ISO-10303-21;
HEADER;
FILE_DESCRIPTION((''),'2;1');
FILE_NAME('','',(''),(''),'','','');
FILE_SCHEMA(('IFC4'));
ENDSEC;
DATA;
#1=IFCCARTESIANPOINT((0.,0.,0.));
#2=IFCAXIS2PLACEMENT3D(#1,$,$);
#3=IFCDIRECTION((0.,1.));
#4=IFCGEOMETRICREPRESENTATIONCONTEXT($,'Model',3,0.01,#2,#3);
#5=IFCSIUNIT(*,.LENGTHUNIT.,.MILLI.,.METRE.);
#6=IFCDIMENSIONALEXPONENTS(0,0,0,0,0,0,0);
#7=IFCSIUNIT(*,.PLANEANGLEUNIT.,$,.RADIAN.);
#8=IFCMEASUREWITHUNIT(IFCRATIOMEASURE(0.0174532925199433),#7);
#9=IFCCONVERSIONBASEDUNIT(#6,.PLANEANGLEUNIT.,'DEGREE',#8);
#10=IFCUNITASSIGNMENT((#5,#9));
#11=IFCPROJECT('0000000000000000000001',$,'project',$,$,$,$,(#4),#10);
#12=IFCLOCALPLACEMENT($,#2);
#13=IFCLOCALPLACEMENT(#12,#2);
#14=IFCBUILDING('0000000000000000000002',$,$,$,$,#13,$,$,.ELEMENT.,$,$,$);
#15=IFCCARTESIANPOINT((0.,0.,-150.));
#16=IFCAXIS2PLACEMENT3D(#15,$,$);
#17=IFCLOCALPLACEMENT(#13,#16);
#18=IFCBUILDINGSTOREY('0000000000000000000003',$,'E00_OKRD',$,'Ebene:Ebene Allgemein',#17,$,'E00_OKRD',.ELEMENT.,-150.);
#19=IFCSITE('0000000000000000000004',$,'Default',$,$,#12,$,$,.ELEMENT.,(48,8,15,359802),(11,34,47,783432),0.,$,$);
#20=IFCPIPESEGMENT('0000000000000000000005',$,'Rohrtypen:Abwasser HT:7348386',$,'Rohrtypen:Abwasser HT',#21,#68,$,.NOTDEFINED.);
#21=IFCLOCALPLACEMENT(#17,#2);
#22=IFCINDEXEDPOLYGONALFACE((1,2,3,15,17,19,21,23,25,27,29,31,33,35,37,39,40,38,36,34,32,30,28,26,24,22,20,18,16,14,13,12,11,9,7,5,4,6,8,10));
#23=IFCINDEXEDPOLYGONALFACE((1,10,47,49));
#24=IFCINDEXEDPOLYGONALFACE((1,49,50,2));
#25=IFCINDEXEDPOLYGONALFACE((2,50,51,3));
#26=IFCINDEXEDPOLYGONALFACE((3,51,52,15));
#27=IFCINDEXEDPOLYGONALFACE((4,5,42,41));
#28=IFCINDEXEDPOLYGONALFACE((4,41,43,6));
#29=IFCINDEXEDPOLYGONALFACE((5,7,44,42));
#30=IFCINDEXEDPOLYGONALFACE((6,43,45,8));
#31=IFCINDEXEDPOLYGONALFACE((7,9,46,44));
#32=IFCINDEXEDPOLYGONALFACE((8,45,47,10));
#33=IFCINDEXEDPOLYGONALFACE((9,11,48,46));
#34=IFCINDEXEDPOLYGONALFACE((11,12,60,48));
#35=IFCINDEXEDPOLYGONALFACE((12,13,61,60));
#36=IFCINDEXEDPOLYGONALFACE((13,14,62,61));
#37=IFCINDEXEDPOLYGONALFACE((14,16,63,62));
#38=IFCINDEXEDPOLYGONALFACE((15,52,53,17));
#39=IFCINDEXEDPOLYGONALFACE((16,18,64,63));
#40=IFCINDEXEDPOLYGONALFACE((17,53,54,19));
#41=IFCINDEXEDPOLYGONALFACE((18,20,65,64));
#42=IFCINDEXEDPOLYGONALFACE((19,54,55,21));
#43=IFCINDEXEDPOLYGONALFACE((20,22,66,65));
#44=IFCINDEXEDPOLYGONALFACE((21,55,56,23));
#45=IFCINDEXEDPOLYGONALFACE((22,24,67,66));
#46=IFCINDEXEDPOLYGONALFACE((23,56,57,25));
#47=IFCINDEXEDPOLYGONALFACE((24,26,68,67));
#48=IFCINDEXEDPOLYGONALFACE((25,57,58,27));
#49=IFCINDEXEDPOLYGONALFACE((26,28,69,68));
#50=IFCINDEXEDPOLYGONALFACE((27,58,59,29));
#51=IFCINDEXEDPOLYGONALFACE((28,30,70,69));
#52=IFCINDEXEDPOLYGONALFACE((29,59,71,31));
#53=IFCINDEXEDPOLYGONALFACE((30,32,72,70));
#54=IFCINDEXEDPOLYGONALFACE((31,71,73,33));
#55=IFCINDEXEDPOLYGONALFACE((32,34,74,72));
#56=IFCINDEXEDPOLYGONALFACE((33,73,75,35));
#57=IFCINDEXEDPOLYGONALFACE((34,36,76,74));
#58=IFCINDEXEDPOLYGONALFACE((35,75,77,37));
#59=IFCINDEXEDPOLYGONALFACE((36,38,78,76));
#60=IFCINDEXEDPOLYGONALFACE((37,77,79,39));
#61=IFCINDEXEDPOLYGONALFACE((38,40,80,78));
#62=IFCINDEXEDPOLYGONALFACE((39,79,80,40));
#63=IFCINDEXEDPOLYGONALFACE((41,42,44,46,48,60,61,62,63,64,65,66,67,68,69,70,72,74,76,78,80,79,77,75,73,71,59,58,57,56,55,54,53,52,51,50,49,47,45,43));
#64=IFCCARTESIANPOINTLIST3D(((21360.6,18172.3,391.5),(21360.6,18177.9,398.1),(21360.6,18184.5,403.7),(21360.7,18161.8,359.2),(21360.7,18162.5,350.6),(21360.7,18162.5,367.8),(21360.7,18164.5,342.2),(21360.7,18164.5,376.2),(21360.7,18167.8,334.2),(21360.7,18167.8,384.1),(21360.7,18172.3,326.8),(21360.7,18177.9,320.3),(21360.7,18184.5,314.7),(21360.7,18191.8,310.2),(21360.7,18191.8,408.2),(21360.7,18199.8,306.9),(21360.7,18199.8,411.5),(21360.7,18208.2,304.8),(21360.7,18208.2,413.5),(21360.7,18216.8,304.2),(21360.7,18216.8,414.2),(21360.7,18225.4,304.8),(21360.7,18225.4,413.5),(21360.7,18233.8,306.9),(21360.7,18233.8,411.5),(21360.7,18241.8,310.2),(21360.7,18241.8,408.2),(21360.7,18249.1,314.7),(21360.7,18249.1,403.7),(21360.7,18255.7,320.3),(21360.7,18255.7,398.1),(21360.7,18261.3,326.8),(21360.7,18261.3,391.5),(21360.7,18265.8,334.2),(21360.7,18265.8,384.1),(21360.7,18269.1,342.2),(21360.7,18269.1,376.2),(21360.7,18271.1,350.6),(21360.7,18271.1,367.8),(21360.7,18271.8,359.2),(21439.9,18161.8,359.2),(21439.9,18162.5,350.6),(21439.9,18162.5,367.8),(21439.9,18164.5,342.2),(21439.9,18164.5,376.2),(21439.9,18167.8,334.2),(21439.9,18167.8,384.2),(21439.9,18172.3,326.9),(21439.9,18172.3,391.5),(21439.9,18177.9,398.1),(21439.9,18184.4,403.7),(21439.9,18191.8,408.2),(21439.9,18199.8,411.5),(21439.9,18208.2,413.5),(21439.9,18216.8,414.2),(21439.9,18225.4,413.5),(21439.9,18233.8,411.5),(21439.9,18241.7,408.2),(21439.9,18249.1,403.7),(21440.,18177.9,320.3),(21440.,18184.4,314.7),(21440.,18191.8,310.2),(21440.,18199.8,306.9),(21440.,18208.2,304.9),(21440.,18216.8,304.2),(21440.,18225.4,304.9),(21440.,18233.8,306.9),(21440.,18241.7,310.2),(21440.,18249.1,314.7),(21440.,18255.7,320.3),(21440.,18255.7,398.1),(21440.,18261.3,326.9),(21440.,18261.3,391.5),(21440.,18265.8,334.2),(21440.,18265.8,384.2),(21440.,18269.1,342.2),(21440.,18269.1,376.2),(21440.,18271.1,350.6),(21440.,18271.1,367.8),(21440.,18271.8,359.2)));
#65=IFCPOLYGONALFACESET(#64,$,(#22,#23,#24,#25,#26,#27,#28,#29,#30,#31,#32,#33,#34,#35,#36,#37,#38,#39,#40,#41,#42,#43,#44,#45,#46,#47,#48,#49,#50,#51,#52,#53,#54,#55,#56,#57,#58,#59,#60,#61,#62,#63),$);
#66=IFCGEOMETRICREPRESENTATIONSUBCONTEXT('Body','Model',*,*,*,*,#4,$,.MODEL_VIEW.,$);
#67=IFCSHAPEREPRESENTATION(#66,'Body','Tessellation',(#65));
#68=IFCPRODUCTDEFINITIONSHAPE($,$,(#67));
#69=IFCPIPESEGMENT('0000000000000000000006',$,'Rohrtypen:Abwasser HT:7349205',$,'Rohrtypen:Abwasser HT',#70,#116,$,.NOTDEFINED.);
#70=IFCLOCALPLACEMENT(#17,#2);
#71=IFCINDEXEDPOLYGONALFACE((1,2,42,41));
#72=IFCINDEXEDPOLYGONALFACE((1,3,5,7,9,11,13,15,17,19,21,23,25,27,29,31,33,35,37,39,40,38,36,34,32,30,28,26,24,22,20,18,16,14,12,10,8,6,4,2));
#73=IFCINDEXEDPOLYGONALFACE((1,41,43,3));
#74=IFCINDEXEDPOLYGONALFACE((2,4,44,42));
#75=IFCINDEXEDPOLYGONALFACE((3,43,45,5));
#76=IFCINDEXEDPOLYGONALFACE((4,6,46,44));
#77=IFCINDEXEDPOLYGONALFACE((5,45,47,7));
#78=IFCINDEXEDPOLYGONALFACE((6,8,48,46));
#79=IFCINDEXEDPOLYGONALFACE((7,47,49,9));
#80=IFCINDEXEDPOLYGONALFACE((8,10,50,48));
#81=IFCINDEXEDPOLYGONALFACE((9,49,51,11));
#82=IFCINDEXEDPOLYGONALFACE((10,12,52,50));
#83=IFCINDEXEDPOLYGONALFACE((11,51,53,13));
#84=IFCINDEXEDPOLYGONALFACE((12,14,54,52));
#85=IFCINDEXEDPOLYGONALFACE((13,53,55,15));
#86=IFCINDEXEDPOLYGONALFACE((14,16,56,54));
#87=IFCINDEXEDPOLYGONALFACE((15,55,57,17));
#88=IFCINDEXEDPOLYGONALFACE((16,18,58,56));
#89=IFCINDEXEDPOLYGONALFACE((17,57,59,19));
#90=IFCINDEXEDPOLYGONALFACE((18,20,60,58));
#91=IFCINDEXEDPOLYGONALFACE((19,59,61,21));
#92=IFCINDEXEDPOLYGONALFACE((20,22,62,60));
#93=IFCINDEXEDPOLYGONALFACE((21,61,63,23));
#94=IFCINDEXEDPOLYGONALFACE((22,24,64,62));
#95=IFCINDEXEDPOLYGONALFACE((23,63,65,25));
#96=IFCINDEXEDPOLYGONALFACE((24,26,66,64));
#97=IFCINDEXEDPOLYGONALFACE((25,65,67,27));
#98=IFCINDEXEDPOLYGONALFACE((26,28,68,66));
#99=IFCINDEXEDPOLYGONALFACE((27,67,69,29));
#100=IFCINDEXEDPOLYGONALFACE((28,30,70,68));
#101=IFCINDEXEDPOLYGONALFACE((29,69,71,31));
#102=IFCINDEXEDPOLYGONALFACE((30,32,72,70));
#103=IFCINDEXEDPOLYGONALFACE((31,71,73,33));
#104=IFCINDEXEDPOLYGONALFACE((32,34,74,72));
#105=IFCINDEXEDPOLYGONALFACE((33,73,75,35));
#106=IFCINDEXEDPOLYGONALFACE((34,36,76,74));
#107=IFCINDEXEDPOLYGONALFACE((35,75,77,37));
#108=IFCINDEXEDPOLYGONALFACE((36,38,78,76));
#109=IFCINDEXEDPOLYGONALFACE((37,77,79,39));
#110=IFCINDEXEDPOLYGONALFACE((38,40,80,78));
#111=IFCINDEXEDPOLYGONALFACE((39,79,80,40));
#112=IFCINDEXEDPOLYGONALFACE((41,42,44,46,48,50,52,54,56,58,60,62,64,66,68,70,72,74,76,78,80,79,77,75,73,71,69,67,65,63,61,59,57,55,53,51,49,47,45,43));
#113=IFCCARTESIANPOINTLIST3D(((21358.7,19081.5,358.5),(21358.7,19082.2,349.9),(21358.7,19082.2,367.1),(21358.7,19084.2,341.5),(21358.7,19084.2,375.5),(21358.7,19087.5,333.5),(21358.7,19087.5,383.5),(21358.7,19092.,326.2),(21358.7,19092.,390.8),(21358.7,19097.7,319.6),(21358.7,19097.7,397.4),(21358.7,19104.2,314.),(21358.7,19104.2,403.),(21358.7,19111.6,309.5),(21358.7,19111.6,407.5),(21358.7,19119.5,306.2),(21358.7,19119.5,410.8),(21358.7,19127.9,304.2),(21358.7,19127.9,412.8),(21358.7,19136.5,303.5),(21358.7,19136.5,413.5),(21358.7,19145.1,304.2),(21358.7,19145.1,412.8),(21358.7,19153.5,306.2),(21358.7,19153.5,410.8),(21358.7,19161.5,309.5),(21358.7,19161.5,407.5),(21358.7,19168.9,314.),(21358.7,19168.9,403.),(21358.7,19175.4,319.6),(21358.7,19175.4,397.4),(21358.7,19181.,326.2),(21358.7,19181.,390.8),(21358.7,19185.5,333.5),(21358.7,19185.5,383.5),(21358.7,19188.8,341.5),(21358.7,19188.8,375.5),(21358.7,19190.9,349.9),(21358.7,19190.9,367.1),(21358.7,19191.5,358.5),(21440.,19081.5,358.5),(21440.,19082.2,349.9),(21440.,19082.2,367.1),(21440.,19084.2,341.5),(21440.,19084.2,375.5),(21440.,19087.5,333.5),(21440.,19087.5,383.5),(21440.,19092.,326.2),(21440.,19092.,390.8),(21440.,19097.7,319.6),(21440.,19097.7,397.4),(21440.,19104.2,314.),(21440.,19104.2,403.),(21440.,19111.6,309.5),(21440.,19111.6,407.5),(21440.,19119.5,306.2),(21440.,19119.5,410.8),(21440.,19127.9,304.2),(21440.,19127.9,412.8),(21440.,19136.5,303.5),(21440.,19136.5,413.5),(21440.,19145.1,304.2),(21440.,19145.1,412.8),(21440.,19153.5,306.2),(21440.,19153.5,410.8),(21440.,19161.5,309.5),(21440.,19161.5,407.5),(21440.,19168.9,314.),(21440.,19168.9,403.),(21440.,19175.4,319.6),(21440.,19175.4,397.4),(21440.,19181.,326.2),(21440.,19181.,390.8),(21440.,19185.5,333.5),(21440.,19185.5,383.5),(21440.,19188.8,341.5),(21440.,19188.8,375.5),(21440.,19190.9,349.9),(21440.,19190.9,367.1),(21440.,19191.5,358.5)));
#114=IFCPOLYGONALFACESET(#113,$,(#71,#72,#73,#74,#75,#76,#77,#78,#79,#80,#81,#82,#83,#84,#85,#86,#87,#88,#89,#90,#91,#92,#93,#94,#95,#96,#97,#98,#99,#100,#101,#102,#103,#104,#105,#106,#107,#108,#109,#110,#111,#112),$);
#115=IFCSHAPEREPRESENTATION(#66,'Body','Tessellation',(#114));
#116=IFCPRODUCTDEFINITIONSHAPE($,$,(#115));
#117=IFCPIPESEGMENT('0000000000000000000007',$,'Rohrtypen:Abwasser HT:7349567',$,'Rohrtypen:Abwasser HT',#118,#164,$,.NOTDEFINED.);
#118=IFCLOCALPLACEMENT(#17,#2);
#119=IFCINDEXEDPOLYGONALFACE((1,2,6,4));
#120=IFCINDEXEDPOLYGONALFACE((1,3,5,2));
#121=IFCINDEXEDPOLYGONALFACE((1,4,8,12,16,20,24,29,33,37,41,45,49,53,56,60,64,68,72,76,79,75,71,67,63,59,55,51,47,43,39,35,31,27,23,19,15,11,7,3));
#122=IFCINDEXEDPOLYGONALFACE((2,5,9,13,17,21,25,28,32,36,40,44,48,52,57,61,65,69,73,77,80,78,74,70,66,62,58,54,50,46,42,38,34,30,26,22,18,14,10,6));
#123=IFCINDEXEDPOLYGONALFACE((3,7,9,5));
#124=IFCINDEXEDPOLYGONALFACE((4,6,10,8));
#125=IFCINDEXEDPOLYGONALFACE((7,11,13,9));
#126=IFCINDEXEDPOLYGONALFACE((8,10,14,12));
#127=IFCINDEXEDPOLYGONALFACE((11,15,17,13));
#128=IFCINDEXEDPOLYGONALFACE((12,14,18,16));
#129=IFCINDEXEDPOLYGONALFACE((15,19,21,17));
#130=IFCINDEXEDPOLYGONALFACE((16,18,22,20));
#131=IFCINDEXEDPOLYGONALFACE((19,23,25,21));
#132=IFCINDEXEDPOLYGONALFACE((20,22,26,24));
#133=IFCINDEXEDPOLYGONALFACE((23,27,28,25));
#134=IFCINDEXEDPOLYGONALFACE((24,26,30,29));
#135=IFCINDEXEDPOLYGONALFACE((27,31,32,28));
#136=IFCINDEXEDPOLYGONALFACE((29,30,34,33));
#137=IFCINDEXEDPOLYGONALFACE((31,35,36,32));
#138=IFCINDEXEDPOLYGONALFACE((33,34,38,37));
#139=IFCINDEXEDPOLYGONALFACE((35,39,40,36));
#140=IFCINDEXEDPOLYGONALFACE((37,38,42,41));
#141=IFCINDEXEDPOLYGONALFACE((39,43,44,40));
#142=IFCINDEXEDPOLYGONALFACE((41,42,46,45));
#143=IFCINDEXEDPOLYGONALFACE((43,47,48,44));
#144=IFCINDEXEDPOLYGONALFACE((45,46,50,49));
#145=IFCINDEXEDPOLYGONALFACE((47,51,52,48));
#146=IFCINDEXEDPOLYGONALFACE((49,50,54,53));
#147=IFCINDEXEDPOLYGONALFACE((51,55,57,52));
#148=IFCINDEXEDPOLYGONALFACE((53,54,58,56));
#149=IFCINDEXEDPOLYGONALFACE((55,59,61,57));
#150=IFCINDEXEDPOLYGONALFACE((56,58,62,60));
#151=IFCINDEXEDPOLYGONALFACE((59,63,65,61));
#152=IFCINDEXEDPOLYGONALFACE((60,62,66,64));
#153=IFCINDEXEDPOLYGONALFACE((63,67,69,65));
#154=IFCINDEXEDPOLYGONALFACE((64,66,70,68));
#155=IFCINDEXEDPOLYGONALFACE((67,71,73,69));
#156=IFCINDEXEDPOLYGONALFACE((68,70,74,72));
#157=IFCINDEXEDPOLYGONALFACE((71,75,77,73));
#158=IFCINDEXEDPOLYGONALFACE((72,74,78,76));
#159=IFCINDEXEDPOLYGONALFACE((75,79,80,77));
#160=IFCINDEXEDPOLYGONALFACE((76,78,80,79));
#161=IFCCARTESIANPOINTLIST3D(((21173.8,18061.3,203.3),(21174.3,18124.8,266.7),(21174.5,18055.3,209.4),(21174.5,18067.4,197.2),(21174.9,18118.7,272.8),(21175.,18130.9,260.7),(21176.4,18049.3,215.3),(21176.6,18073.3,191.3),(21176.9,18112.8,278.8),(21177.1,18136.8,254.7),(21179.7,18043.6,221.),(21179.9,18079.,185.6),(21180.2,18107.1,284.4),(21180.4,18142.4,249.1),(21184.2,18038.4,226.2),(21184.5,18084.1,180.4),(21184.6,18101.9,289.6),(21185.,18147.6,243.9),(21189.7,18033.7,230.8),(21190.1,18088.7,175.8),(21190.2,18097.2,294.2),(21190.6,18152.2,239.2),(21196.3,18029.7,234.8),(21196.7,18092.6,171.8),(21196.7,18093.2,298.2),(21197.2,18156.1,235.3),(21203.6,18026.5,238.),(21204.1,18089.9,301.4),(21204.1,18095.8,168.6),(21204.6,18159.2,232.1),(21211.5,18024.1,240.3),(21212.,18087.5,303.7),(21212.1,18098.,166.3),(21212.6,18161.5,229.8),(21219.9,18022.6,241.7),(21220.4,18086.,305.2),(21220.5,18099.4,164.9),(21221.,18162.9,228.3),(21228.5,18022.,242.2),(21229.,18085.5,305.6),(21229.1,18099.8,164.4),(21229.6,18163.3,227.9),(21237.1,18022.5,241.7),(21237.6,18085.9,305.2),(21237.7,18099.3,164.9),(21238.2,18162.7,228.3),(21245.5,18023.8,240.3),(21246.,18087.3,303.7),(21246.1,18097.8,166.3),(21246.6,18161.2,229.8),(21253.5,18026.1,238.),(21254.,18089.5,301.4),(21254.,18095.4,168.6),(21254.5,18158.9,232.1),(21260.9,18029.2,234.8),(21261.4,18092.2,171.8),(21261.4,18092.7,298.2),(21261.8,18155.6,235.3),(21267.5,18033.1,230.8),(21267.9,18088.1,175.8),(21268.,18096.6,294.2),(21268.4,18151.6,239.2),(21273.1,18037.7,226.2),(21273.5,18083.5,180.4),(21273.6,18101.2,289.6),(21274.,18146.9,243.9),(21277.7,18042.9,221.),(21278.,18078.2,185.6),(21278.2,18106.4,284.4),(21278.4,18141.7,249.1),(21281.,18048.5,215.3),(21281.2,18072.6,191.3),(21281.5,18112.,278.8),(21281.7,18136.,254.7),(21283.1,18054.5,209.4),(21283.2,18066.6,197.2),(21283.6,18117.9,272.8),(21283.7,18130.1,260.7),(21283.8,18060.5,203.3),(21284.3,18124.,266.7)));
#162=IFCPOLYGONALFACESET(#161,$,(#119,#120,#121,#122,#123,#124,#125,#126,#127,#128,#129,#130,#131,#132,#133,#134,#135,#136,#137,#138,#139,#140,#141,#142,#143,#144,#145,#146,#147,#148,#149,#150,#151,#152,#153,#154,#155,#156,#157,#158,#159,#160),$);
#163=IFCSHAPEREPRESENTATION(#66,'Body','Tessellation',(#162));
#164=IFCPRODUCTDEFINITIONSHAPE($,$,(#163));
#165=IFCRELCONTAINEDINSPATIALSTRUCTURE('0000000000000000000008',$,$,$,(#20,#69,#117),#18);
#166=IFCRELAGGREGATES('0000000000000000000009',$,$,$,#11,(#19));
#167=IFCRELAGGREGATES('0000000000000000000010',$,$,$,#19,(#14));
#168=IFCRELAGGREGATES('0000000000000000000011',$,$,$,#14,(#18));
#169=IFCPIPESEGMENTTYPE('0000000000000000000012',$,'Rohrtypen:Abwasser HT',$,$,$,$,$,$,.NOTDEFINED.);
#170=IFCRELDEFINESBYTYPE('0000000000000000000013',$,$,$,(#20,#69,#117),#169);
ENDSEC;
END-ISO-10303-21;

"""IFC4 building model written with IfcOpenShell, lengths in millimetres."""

from ifc_helpers import new_model, entity, si_unit, converted_unit, direction, frame, origin, place, context, subcontext, project, spatial, indexed_curve, outline, extrude, type_object, element, save


model = new_model("IFC4")

# Units and contexts
model_context = context("Model", 3, precision=0.01, world=origin(), true_north=direction((0.0, 1.0)))
body_context = subcontext(model_context, "Body", "Model", "MODEL_VIEW")
ifc_project = project(units=[si_unit("LENGTHUNIT", "METRE", prefix="MILLI"), converted_unit("PLANEANGLEUNIT", "DEGREE", entity("IfcRatioMeasure", 0.0174532925199433), si_unit("PLANEANGLEUNIT", "RADIAN"), dimensions=[0, 0, 0, 0, 0, 0, 0])], contexts=[model_context])

# Site, building, storey
site_placement = place(None, origin())
site = spatial("IfcSite", under=ifc_project, at=site_placement, Name="Default", CompositionType="ELEMENT", RefLatitude=(48, 8, 15, 359802), RefLongitude=(11, 34, 47, 783432), RefElevation=0.0)
building_placement = place(site_placement, origin())
building = spatial("IfcBuilding", under=site, at=building_placement, CompositionType="ELEMENT")
storey_placement = place(building_placement, frame((0.0, 0.0, -150.0)))
storey = spatial("IfcBuildingStorey", under=building, at=storey_placement, Name="E00_OKRD", ObjectType="Ebene:Ebene Allgemein", LongName="E00_OKRD", CompositionType="ELEMENT", Elevation=-150.0)

# Pipe segments
pipe_segment_type_1 = type_object("IfcPipeSegmentType", Name="Rohrtypen:Abwasser HT", PredefinedType="NOTDEFINED")
pipe_segment_1_placement = place(storey_placement, origin())
element("IfcPipeSegment", 1, at=pipe_segment_1_placement, inside=storey, type_object=pipe_segment_type_1, Name="Rohrtypen:Abwasser HT:7348386", ObjectType="Rohrtypen:Abwasser HT", PredefinedType="NOTDEFINED", context=body_context, shape_type="SweptSolid", body=[
    extrude(outline(indexed_curve([(55.0, 0.0), (54.3, 8.6), (52.3, 17.0), (49.0, 25.0), (44.5, 32.3), (38.9, 38.9), (32.3, 44.5), (25.0, 49.0), (17.0, 52.3), (8.6, 54.3), (0.0, 55.0), (-8.6, 54.3), (-17.0, 52.3), (-25.0, 49.0), (-32.3, 44.5), (-38.9, 38.9), (-44.5, 32.3), (-49.0, 25.0), (-52.3, 17.0), (-54.3, 8.6), (-55.0, 0.0), (-54.3, -8.6), (-52.3, -17.0), (-49.0, -25.0), (-44.5, -32.3), (-38.9, -38.9), (-32.3, -44.5), (-25.0, -49.0), (-17.0, -52.3), (-8.6, -54.3), (0.0, -55.0), (8.6, -54.3), (17.0, -52.3), (25.0, -49.0), (32.3, -44.5), (38.9, -38.9), (44.5, -32.3), (49.0, -25.0), (52.3, -17.0), (54.3, -8.6), (55.0, 0.0)], self_intersect=False)), frame((21360.7, 18216.8, 359.2), z_axis=(1.0, -0.000427, 0.000427), x_axis=(0.000427, 1.0, 0.0)), (0.0, 0.0, 1.0), 79.3),
])
pipe_segment_2_placement = place(storey_placement, origin())
element("IfcPipeSegment", 2, at=pipe_segment_2_placement, inside=storey, type_object=pipe_segment_type_1, Name="Rohrtypen:Abwasser HT:7349205", ObjectType="Rohrtypen:Abwasser HT", PredefinedType="NOTDEFINED", context=body_context, shape_type="SweptSolid", body=[
    extrude(outline(indexed_curve([(55.0, 0.0), (54.3, 8.6), (52.3, 17.0), (49.0, 25.0), (44.5, 32.3), (38.9, 38.9), (32.3, 44.5), (25.0, 49.0), (17.0, 52.3), (8.6, 54.3), (0.0, 55.0), (-8.6, 54.3), (-17.0, 52.3), (-25.0, 49.0), (-32.3, 44.5), (-38.9, 38.9), (-44.5, 32.3), (-49.0, 25.0), (-52.3, 17.0), (-54.3, 8.6), (-55.0, 0.0), (-54.3, -8.6), (-52.3, -17.0), (-49.0, -25.0), (-44.5, -32.3), (-38.9, -38.9), (-32.3, -44.5), (-25.0, -49.0), (-17.0, -52.3), (-8.6, -54.3), (0.0, -55.0), (8.6, -54.3), (17.0, -52.3), (25.0, -49.0), (32.3, -44.5), (38.9, -38.9), (44.5, -32.3), (49.0, -25.0), (52.3, -17.0), (54.3, -8.6), (55.0, 0.0)], self_intersect=False)), frame((21358.7, 19136.5, 358.5), z_axis=(1.0, 0.0, 0.0), x_axis=(0.0, 1.0, 0.0)), (0.0, 0.0, 1.0), 81.3),
])
pipe_segment_3_placement = place(storey_placement, origin())
element("IfcPipeSegment", 3, at=pipe_segment_3_placement, inside=storey, type_object=pipe_segment_type_1, Name="Rohrtypen:Abwasser HT:7349567", ObjectType="Rohrtypen:Abwasser HT", PredefinedType="NOTDEFINED", context=body_context, shape_type="SweptSolid", body=[
    extrude(outline(indexed_curve([(55.0, 0.0), (54.3, 8.6), (52.3, 17.0), (49.0, 25.0), (44.5, 32.3), (38.9, 38.9), (32.3, 44.5), (25.0, 49.0), (17.0, 52.3), (8.6, 54.3), (0.0, 55.0), (-8.6, 54.3), (-17.0, 52.3), (-25.0, 49.0), (-32.3, 44.5), (-38.9, 38.9), (-44.5, 32.3), (-49.0, 25.0), (-52.3, 17.0), (-54.3, 8.6), (-55.0, 0.0), (-54.3, -8.6), (-52.3, -17.0), (-49.0, -25.0), (-44.5, -32.3), (-38.9, -38.9), (-32.3, -44.5), (-25.0, -49.0), (-17.0, -52.3), (-8.6, -54.3), (0.0, -55.0), (8.6, -54.3), (17.0, -52.3), (25.0, -49.0), (32.3, -44.5), (38.9, -38.9), (44.5, -32.3), (49.0, -25.0), (52.3, -17.0), (54.3, -8.6), (55.0, 0.0)], self_intersect=False)), frame((21228.8, 18060.9, 203.3), z_axis=(0.005242, 0.707101, 0.707093), x_axis=(-0.999973, 0.007413, 0.0)), (0.0, 0.0, 1.0), 89.7),
])

save(model, "model.ifc")
